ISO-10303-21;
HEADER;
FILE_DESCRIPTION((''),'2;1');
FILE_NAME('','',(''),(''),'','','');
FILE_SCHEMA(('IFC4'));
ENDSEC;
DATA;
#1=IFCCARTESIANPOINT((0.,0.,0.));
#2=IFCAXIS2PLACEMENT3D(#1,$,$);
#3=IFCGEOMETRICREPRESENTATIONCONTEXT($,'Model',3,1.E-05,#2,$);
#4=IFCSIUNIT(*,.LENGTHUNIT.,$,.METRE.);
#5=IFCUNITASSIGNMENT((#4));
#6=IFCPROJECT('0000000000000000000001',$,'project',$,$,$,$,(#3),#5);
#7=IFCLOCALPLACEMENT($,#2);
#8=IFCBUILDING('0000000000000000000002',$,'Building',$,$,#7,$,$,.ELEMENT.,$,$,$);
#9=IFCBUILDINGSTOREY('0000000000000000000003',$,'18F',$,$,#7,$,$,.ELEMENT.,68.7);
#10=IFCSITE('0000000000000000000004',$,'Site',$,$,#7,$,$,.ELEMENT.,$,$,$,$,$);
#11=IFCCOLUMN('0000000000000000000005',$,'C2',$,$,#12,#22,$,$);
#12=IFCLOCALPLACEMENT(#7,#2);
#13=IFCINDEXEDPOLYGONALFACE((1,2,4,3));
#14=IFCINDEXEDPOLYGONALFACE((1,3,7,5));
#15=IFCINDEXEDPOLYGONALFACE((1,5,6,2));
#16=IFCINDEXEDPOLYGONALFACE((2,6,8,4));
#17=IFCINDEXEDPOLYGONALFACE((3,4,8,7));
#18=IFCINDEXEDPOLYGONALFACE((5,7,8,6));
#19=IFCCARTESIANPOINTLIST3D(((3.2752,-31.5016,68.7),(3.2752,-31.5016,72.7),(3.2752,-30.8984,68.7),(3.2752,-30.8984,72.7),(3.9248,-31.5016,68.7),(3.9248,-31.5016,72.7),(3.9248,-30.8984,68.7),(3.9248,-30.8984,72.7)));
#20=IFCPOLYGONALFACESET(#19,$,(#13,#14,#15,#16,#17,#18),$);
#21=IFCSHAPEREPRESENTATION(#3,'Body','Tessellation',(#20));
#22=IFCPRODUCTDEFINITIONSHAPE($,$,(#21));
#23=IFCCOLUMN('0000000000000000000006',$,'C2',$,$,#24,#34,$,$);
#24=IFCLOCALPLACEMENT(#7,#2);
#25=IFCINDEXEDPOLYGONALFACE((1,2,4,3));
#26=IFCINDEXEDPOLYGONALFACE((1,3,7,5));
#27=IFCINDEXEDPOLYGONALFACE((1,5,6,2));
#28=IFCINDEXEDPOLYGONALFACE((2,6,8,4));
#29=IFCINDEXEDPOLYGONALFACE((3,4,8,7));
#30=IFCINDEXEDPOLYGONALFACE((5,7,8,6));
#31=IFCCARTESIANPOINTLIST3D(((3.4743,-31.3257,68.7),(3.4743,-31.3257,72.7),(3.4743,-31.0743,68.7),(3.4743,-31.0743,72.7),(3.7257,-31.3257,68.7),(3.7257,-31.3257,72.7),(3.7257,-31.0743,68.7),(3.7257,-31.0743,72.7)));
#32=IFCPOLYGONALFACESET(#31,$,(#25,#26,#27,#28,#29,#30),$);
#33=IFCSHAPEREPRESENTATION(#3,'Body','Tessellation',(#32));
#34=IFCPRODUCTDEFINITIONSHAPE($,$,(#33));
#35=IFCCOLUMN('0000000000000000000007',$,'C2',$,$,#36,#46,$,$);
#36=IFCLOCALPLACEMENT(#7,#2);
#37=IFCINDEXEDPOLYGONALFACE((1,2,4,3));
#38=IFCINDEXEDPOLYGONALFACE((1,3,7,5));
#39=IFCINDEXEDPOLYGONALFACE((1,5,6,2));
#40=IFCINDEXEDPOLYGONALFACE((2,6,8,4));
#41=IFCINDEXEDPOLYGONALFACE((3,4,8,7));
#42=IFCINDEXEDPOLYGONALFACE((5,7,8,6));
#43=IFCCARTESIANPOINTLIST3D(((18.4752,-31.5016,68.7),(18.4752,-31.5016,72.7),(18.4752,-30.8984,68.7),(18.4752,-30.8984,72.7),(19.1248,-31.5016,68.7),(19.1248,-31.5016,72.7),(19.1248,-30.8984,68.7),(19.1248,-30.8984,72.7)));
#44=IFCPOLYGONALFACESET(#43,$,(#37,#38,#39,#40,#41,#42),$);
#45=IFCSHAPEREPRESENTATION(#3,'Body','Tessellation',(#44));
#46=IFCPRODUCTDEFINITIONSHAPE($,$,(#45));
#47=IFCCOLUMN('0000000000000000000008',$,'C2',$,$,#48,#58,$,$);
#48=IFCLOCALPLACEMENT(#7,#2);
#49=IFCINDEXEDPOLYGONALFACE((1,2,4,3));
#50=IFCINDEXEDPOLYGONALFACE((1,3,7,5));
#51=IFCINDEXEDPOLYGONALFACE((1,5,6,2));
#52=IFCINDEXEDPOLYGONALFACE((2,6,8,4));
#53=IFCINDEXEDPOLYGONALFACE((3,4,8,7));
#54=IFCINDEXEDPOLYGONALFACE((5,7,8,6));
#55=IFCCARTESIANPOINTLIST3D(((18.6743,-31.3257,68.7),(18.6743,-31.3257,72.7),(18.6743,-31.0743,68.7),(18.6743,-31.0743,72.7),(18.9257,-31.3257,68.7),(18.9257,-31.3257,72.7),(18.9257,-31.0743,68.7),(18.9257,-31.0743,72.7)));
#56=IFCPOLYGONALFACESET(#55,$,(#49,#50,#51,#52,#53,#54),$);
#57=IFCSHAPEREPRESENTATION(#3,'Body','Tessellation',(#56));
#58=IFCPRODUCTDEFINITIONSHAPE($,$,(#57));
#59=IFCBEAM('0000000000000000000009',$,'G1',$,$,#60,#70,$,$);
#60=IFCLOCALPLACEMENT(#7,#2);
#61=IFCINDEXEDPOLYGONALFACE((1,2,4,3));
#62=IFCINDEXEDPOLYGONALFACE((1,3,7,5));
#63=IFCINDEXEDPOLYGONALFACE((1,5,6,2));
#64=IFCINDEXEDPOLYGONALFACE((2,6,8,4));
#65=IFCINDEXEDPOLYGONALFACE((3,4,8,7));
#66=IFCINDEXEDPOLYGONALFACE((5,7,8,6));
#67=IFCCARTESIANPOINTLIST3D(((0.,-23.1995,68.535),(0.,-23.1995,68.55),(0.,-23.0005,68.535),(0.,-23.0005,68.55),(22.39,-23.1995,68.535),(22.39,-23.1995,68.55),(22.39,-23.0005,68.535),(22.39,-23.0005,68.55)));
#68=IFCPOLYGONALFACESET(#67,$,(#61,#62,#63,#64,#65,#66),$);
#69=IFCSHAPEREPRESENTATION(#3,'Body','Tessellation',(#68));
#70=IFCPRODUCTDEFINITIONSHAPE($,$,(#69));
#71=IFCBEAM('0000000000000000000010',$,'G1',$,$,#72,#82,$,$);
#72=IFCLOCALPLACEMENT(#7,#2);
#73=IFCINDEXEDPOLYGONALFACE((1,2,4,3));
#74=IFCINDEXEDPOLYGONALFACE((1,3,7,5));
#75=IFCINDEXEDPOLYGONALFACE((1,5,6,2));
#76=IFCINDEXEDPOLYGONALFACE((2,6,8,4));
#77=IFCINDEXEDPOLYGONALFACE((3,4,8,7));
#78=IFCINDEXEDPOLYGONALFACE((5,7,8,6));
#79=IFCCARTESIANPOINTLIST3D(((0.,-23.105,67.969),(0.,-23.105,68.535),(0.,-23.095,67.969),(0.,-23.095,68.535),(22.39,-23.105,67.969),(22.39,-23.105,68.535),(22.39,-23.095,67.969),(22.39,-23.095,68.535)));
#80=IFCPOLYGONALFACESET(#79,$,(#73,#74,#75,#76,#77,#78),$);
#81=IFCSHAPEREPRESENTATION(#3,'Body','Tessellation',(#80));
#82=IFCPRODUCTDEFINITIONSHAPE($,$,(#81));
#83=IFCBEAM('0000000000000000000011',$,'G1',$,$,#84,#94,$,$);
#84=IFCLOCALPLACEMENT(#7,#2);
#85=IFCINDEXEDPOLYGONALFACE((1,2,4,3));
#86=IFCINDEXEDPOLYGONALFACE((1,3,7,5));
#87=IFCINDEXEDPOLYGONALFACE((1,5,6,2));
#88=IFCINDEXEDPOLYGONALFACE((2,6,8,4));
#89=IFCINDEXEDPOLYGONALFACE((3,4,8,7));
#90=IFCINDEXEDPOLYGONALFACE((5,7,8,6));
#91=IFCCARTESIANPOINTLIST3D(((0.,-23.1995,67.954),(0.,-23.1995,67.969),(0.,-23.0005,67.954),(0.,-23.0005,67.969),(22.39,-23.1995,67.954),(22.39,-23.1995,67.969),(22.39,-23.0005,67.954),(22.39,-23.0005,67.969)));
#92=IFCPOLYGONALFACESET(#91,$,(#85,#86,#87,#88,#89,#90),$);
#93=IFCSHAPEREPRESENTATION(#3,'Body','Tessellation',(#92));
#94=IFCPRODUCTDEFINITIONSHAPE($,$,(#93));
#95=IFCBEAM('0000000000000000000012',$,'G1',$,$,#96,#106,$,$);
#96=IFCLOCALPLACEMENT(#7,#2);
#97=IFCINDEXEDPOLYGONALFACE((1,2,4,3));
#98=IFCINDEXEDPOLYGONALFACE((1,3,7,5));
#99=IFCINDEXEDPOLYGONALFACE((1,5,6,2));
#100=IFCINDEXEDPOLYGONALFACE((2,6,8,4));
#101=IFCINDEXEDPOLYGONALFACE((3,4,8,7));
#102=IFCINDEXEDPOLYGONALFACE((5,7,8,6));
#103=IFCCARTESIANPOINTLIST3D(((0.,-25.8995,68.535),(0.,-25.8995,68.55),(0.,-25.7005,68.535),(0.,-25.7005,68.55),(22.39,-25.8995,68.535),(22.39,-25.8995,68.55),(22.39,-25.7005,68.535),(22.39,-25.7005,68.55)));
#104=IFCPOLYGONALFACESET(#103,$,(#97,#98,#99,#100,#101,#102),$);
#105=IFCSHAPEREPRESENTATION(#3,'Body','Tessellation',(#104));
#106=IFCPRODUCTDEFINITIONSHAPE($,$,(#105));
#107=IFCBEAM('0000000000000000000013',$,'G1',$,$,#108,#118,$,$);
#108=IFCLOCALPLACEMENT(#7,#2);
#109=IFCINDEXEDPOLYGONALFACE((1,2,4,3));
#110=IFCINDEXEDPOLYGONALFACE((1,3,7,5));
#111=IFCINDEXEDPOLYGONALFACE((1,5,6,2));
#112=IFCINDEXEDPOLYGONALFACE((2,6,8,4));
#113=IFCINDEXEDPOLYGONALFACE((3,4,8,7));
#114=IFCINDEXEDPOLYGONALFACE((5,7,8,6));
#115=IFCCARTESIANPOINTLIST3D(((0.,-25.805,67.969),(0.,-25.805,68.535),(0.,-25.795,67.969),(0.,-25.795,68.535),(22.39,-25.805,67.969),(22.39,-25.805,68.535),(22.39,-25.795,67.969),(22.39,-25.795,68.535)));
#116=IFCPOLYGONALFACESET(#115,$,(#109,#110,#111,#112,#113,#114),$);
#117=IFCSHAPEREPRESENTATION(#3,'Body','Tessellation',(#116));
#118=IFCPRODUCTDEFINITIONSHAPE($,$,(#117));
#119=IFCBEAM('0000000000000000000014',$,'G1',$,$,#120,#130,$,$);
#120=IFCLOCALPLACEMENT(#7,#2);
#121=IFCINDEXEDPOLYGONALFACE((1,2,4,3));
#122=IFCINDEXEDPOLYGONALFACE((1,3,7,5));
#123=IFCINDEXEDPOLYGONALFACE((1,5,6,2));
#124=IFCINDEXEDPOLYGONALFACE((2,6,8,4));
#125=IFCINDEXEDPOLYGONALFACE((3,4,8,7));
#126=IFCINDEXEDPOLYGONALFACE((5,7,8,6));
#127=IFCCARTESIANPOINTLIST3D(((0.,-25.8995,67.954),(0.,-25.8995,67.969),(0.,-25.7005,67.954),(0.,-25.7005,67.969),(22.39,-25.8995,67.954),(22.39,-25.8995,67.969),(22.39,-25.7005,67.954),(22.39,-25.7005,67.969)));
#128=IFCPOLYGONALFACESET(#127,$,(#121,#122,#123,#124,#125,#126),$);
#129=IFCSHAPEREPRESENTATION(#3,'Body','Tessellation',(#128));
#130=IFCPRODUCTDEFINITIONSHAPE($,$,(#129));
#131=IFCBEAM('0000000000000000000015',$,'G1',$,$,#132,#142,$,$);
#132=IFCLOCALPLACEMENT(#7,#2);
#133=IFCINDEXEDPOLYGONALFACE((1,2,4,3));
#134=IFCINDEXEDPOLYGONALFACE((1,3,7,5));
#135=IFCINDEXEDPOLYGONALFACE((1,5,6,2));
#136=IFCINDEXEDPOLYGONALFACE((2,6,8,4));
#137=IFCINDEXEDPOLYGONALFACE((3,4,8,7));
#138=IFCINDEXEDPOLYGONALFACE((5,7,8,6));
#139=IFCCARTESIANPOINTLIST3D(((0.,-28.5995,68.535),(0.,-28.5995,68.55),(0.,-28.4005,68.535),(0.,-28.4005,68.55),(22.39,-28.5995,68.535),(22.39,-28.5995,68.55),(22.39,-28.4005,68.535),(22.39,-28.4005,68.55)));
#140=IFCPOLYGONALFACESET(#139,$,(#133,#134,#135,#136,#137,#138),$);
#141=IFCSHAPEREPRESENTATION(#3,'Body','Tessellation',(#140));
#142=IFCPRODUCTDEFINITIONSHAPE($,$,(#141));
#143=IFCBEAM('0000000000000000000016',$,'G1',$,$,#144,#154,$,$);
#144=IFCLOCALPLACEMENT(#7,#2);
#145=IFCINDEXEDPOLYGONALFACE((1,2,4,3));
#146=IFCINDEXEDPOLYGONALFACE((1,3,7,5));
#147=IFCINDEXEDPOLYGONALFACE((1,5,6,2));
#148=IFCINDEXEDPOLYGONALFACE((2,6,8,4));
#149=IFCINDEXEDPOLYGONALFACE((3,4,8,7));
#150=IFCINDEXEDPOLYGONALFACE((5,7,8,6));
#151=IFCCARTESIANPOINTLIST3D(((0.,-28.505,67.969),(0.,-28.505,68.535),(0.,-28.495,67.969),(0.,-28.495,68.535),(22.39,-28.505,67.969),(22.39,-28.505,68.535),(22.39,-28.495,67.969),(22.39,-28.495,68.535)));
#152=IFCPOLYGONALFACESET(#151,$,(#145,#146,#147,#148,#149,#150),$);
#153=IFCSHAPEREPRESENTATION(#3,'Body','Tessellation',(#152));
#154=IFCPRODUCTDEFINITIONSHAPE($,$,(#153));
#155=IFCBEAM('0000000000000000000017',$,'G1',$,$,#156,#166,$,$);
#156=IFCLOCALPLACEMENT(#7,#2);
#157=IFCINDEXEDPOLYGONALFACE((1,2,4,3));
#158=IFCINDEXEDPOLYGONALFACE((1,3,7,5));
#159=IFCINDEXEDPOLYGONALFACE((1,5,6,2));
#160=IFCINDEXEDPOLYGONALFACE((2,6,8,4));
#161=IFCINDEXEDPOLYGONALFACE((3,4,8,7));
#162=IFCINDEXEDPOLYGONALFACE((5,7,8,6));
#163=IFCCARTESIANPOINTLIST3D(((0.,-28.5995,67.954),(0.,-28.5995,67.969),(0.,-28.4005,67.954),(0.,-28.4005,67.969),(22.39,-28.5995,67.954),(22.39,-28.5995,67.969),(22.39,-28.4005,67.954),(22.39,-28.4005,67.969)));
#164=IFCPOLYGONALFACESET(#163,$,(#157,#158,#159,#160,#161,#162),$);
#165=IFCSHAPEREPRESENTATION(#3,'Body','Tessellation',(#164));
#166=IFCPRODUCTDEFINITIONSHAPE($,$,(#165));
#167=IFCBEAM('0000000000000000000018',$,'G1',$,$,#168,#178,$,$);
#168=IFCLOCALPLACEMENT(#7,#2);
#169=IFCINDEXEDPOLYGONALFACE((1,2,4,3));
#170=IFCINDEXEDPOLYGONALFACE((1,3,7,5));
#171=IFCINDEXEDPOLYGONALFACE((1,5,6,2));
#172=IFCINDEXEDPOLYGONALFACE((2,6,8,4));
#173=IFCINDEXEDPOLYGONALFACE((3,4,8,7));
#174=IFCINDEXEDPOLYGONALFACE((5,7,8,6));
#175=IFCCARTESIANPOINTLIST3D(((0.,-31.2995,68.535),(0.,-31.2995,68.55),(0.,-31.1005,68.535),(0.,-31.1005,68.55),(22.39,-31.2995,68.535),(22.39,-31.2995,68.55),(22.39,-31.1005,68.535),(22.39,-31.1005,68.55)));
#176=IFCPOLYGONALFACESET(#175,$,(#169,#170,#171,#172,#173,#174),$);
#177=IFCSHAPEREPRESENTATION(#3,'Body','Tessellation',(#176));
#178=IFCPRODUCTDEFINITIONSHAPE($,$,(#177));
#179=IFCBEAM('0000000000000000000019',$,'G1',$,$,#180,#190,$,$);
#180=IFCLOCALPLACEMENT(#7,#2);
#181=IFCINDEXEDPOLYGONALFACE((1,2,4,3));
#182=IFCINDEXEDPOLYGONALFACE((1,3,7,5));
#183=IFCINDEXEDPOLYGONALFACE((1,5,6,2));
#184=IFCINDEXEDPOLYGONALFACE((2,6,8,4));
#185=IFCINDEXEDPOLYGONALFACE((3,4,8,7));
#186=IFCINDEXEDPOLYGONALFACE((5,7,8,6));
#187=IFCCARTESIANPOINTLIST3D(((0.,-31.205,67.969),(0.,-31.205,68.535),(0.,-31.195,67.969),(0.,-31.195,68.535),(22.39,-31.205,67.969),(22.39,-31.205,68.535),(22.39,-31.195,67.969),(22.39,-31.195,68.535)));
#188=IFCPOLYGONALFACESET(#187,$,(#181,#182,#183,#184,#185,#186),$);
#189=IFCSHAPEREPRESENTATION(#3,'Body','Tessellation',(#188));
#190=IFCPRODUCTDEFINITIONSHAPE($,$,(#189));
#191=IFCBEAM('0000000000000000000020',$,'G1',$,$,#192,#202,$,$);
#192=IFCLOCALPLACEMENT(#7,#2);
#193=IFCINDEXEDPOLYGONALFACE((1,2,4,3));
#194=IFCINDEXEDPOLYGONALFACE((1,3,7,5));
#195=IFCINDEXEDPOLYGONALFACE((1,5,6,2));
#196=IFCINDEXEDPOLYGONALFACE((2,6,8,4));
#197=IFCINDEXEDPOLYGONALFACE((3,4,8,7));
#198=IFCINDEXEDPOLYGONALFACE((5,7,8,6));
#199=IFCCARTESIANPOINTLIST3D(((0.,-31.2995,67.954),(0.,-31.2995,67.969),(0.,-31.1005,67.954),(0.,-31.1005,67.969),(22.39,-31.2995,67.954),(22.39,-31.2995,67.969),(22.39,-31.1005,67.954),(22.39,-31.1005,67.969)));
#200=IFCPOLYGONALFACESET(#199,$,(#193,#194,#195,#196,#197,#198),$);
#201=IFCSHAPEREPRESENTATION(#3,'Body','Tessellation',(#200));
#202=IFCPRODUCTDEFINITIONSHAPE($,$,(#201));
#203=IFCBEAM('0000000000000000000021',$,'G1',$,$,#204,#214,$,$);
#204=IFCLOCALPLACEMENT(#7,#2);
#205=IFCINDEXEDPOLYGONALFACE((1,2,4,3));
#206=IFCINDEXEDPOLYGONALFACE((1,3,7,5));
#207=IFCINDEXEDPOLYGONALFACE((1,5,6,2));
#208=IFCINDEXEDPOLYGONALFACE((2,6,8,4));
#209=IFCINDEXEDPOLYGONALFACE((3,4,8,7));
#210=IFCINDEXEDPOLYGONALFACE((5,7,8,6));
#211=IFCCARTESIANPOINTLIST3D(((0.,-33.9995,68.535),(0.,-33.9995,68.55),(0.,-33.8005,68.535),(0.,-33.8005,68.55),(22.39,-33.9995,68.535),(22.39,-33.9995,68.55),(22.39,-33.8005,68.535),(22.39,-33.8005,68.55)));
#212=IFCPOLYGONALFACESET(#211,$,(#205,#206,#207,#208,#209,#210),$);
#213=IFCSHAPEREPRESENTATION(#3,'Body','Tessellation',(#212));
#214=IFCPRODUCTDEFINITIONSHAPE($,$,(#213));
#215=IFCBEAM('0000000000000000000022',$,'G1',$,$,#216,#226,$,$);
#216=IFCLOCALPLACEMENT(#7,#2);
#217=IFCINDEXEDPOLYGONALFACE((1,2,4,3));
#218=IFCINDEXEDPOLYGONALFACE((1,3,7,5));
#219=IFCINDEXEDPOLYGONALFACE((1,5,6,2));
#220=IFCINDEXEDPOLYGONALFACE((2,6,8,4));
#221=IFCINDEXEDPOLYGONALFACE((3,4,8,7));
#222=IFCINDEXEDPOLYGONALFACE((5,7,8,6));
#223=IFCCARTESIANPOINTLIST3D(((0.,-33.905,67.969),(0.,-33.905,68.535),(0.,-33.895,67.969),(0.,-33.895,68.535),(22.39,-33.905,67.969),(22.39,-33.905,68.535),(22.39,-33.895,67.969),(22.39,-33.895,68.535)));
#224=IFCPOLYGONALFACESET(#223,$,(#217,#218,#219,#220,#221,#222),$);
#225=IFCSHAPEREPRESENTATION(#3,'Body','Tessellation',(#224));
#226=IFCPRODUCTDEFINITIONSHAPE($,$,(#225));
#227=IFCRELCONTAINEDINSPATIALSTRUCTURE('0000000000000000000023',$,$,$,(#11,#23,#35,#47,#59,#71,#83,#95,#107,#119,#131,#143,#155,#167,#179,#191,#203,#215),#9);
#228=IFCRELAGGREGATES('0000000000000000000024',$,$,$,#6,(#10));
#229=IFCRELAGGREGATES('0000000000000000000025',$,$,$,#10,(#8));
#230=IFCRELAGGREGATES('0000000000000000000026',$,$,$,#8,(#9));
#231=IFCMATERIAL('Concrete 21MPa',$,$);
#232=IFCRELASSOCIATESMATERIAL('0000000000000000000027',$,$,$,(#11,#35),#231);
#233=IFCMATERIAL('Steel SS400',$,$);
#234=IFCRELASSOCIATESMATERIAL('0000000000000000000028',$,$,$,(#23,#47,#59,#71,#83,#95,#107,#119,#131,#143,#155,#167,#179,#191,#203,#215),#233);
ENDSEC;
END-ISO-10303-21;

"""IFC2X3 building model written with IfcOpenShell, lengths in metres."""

from ifc_helpers import new_model, si_unit, frame, origin, origin_2d, place, context, project, spatial, rectangle, extrude, material, element, save


model = new_model("IFC2X3")

# Units and contexts
model_context = context("Model", 3, precision=1e-05, world=origin())
ifc_project = project(units=[si_unit("LENGTHUNIT", "METRE")], contexts=[model_context])

# Site, building, storey
placement = place(None, origin())
site = spatial("IfcSite", under=ifc_project, at=placement, Name="Site", CompositionType="ELEMENT")
building = spatial("IfcBuilding", under=site, at=placement, Name="Building", CompositionType="ELEMENT")
storey = spatial("IfcBuildingStorey", under=building, at=placement, Name="18F", CompositionType="ELEMENT", Elevation=68.7)

# Columns
ifc_material_1 = material(Name="Concrete 21MPa")
column_1_placement = place(None, frame((3.6, -31.2, 68.7)))
element("IfcColumn", 1, at=column_1_placement, inside=storey, material=ifc_material_1, Name="C2", context=model_context, shape_type="SweptSolid", body=[
    extrude(rectangle(XDim=0.6496, YDim=0.6032, at=origin_2d()), origin(), (0.0, 0.0, 1.0), 4.0),
])
ifc_material_2 = material(Name="Steel SS400")
column_2_placement = place(None, frame((3.6, -31.2, 68.7)))
element("IfcColumn", 2, at=column_2_placement, inside=storey, material=ifc_material_2, Name="C2", context=model_context, shape_type="SweptSolid", body=[
    extrude(rectangle(XDim=0.2513, YDim=0.2513, at=origin_2d()), origin(), (0.0, 0.0, 1.0), 4.0),
])
column_3_placement = place(None, frame((18.8, -31.2, 68.7)))
element("IfcColumn", 3, at=column_3_placement, inside=storey, material=ifc_material_1, Name="C2", context=model_context, shape_type="SweptSolid", body=[
    extrude(rectangle(XDim=0.6496, YDim=0.6032, at=origin_2d()), origin(), (0.0, 0.0, 1.0), 4.0),
])
column_4_placement = place(None, frame((18.8, -31.2, 68.7)))
element("IfcColumn", 4, at=column_4_placement, inside=storey, material=ifc_material_2, Name="C2", context=model_context, shape_type="SweptSolid", body=[
    extrude(rectangle(XDim=0.2513, YDim=0.2513, at=origin_2d()), origin(), (0.0, 0.0, 1.0), 4.0),
])

# Beams
beam_1_placement = place(None, frame((11.195, -23.1, 68.535)))
element("IfcBeam", 5, at=beam_1_placement, inside=storey, material=ifc_material_2, Name="G1", context=model_context, shape_type="SweptSolid", body=[
    extrude(rectangle(XDim=22.39, YDim=0.199, at=origin_2d()), origin(), (0.0, 0.0, 1.0), 0.015),
])
beam_2_placement = place(None, frame((11.195, -23.1, 67.969)))
element("IfcBeam", 6, at=beam_2_placement, inside=storey, material=ifc_material_2, Name="G1", context=model_context, shape_type="SweptSolid", body=[
    extrude(rectangle(XDim=22.39, YDim=0.01, at=origin_2d()), origin(), (0.0, 0.0, 1.0), 0.566),
])
for number, where, name in (
    (7, (11.195, -23.1, 67.954), "G1"),
    (8, (11.195, -25.8, 68.535), "G1"),
):
    element("IfcBeam", number, at=place(None, frame(where)), inside=storey, material=ifc_material_2, Name=name, context=model_context, shape_type="SweptSolid", body=[
        extrude(rectangle(XDim=22.39, YDim=0.199, at=origin_2d()), origin(), (0.0, 0.0, 1.0), 0.015),
    ])
beam_3_placement = place(None, frame((11.195, -25.8, 67.969)))
element("IfcBeam", 9, at=beam_3_placement, inside=storey, material=ifc_material_2, Name="G1", context=model_context, shape_type="SweptSolid", body=[
    extrude(rectangle(XDim=22.39, YDim=0.01, at=origin_2d()), origin(), (0.0, 0.0, 1.0), 0.566),
])
for number, where, name in (
    (10, (11.195, -25.8, 67.954), "G1"),
    (11, (11.195, -28.5, 68.535), "G1"),
):
    element("IfcBeam", number, at=place(None, frame(where)), inside=storey, material=ifc_material_2, Name=name, context=model_context, shape_type="SweptSolid", body=[
        extrude(rectangle(XDim=22.39, YDim=0.199, at=origin_2d()), origin(), (0.0, 0.0, 1.0), 0.015),
    ])
beam_4_placement = place(None, frame((11.195, -28.5, 67.969)))
element("IfcBeam", 12, at=beam_4_placement, inside=storey, material=ifc_material_2, Name="G1", context=model_context, shape_type="SweptSolid", body=[
    extrude(rectangle(XDim=22.39, YDim=0.01, at=origin_2d()), origin(), (0.0, 0.0, 1.0), 0.566),
])
for number, where, name in (
    (13, (11.195, -28.5, 67.954), "G1"),
    (14, (11.195, -31.2, 68.535), "G1"),
):
    element("IfcBeam", number, at=place(None, frame(where)), inside=storey, material=ifc_material_2, Name=name, context=model_context, shape_type="SweptSolid", body=[
        extrude(rectangle(XDim=22.39, YDim=0.199, at=origin_2d()), origin(), (0.0, 0.0, 1.0), 0.015),
    ])
beam_5_placement = place(None, frame((11.195, -31.2, 67.969)))
element("IfcBeam", 15, at=beam_5_placement, inside=storey, material=ifc_material_2, Name="G1", context=model_context, shape_type="SweptSolid", body=[
    extrude(rectangle(XDim=22.39, YDim=0.01, at=origin_2d()), origin(), (0.0, 0.0, 1.0), 0.566),
])
for number, where, name in (
    (16, (11.195, -31.2, 67.954), "G1"),
    (17, (11.195, -33.9, 68.535), "G1"),
):
    element("IfcBeam", number, at=place(None, frame(where)), inside=storey, material=ifc_material_2, Name=name, context=model_context, shape_type="SweptSolid", body=[
        extrude(rectangle(XDim=22.39, YDim=0.199, at=origin_2d()), origin(), (0.0, 0.0, 1.0), 0.015),
    ])
beam_6_placement = place(None, frame((11.195, -33.9, 67.969)))
element("IfcBeam", 18, at=beam_6_placement, inside=storey, material=ifc_material_2, Name="G1", context=model_context, shape_type="SweptSolid", body=[
    extrude(rectangle(XDim=22.39, YDim=0.01, at=origin_2d()), origin(), (0.0, 0.0, 1.0), 0.566),
])

save(model, "model.ifc")
